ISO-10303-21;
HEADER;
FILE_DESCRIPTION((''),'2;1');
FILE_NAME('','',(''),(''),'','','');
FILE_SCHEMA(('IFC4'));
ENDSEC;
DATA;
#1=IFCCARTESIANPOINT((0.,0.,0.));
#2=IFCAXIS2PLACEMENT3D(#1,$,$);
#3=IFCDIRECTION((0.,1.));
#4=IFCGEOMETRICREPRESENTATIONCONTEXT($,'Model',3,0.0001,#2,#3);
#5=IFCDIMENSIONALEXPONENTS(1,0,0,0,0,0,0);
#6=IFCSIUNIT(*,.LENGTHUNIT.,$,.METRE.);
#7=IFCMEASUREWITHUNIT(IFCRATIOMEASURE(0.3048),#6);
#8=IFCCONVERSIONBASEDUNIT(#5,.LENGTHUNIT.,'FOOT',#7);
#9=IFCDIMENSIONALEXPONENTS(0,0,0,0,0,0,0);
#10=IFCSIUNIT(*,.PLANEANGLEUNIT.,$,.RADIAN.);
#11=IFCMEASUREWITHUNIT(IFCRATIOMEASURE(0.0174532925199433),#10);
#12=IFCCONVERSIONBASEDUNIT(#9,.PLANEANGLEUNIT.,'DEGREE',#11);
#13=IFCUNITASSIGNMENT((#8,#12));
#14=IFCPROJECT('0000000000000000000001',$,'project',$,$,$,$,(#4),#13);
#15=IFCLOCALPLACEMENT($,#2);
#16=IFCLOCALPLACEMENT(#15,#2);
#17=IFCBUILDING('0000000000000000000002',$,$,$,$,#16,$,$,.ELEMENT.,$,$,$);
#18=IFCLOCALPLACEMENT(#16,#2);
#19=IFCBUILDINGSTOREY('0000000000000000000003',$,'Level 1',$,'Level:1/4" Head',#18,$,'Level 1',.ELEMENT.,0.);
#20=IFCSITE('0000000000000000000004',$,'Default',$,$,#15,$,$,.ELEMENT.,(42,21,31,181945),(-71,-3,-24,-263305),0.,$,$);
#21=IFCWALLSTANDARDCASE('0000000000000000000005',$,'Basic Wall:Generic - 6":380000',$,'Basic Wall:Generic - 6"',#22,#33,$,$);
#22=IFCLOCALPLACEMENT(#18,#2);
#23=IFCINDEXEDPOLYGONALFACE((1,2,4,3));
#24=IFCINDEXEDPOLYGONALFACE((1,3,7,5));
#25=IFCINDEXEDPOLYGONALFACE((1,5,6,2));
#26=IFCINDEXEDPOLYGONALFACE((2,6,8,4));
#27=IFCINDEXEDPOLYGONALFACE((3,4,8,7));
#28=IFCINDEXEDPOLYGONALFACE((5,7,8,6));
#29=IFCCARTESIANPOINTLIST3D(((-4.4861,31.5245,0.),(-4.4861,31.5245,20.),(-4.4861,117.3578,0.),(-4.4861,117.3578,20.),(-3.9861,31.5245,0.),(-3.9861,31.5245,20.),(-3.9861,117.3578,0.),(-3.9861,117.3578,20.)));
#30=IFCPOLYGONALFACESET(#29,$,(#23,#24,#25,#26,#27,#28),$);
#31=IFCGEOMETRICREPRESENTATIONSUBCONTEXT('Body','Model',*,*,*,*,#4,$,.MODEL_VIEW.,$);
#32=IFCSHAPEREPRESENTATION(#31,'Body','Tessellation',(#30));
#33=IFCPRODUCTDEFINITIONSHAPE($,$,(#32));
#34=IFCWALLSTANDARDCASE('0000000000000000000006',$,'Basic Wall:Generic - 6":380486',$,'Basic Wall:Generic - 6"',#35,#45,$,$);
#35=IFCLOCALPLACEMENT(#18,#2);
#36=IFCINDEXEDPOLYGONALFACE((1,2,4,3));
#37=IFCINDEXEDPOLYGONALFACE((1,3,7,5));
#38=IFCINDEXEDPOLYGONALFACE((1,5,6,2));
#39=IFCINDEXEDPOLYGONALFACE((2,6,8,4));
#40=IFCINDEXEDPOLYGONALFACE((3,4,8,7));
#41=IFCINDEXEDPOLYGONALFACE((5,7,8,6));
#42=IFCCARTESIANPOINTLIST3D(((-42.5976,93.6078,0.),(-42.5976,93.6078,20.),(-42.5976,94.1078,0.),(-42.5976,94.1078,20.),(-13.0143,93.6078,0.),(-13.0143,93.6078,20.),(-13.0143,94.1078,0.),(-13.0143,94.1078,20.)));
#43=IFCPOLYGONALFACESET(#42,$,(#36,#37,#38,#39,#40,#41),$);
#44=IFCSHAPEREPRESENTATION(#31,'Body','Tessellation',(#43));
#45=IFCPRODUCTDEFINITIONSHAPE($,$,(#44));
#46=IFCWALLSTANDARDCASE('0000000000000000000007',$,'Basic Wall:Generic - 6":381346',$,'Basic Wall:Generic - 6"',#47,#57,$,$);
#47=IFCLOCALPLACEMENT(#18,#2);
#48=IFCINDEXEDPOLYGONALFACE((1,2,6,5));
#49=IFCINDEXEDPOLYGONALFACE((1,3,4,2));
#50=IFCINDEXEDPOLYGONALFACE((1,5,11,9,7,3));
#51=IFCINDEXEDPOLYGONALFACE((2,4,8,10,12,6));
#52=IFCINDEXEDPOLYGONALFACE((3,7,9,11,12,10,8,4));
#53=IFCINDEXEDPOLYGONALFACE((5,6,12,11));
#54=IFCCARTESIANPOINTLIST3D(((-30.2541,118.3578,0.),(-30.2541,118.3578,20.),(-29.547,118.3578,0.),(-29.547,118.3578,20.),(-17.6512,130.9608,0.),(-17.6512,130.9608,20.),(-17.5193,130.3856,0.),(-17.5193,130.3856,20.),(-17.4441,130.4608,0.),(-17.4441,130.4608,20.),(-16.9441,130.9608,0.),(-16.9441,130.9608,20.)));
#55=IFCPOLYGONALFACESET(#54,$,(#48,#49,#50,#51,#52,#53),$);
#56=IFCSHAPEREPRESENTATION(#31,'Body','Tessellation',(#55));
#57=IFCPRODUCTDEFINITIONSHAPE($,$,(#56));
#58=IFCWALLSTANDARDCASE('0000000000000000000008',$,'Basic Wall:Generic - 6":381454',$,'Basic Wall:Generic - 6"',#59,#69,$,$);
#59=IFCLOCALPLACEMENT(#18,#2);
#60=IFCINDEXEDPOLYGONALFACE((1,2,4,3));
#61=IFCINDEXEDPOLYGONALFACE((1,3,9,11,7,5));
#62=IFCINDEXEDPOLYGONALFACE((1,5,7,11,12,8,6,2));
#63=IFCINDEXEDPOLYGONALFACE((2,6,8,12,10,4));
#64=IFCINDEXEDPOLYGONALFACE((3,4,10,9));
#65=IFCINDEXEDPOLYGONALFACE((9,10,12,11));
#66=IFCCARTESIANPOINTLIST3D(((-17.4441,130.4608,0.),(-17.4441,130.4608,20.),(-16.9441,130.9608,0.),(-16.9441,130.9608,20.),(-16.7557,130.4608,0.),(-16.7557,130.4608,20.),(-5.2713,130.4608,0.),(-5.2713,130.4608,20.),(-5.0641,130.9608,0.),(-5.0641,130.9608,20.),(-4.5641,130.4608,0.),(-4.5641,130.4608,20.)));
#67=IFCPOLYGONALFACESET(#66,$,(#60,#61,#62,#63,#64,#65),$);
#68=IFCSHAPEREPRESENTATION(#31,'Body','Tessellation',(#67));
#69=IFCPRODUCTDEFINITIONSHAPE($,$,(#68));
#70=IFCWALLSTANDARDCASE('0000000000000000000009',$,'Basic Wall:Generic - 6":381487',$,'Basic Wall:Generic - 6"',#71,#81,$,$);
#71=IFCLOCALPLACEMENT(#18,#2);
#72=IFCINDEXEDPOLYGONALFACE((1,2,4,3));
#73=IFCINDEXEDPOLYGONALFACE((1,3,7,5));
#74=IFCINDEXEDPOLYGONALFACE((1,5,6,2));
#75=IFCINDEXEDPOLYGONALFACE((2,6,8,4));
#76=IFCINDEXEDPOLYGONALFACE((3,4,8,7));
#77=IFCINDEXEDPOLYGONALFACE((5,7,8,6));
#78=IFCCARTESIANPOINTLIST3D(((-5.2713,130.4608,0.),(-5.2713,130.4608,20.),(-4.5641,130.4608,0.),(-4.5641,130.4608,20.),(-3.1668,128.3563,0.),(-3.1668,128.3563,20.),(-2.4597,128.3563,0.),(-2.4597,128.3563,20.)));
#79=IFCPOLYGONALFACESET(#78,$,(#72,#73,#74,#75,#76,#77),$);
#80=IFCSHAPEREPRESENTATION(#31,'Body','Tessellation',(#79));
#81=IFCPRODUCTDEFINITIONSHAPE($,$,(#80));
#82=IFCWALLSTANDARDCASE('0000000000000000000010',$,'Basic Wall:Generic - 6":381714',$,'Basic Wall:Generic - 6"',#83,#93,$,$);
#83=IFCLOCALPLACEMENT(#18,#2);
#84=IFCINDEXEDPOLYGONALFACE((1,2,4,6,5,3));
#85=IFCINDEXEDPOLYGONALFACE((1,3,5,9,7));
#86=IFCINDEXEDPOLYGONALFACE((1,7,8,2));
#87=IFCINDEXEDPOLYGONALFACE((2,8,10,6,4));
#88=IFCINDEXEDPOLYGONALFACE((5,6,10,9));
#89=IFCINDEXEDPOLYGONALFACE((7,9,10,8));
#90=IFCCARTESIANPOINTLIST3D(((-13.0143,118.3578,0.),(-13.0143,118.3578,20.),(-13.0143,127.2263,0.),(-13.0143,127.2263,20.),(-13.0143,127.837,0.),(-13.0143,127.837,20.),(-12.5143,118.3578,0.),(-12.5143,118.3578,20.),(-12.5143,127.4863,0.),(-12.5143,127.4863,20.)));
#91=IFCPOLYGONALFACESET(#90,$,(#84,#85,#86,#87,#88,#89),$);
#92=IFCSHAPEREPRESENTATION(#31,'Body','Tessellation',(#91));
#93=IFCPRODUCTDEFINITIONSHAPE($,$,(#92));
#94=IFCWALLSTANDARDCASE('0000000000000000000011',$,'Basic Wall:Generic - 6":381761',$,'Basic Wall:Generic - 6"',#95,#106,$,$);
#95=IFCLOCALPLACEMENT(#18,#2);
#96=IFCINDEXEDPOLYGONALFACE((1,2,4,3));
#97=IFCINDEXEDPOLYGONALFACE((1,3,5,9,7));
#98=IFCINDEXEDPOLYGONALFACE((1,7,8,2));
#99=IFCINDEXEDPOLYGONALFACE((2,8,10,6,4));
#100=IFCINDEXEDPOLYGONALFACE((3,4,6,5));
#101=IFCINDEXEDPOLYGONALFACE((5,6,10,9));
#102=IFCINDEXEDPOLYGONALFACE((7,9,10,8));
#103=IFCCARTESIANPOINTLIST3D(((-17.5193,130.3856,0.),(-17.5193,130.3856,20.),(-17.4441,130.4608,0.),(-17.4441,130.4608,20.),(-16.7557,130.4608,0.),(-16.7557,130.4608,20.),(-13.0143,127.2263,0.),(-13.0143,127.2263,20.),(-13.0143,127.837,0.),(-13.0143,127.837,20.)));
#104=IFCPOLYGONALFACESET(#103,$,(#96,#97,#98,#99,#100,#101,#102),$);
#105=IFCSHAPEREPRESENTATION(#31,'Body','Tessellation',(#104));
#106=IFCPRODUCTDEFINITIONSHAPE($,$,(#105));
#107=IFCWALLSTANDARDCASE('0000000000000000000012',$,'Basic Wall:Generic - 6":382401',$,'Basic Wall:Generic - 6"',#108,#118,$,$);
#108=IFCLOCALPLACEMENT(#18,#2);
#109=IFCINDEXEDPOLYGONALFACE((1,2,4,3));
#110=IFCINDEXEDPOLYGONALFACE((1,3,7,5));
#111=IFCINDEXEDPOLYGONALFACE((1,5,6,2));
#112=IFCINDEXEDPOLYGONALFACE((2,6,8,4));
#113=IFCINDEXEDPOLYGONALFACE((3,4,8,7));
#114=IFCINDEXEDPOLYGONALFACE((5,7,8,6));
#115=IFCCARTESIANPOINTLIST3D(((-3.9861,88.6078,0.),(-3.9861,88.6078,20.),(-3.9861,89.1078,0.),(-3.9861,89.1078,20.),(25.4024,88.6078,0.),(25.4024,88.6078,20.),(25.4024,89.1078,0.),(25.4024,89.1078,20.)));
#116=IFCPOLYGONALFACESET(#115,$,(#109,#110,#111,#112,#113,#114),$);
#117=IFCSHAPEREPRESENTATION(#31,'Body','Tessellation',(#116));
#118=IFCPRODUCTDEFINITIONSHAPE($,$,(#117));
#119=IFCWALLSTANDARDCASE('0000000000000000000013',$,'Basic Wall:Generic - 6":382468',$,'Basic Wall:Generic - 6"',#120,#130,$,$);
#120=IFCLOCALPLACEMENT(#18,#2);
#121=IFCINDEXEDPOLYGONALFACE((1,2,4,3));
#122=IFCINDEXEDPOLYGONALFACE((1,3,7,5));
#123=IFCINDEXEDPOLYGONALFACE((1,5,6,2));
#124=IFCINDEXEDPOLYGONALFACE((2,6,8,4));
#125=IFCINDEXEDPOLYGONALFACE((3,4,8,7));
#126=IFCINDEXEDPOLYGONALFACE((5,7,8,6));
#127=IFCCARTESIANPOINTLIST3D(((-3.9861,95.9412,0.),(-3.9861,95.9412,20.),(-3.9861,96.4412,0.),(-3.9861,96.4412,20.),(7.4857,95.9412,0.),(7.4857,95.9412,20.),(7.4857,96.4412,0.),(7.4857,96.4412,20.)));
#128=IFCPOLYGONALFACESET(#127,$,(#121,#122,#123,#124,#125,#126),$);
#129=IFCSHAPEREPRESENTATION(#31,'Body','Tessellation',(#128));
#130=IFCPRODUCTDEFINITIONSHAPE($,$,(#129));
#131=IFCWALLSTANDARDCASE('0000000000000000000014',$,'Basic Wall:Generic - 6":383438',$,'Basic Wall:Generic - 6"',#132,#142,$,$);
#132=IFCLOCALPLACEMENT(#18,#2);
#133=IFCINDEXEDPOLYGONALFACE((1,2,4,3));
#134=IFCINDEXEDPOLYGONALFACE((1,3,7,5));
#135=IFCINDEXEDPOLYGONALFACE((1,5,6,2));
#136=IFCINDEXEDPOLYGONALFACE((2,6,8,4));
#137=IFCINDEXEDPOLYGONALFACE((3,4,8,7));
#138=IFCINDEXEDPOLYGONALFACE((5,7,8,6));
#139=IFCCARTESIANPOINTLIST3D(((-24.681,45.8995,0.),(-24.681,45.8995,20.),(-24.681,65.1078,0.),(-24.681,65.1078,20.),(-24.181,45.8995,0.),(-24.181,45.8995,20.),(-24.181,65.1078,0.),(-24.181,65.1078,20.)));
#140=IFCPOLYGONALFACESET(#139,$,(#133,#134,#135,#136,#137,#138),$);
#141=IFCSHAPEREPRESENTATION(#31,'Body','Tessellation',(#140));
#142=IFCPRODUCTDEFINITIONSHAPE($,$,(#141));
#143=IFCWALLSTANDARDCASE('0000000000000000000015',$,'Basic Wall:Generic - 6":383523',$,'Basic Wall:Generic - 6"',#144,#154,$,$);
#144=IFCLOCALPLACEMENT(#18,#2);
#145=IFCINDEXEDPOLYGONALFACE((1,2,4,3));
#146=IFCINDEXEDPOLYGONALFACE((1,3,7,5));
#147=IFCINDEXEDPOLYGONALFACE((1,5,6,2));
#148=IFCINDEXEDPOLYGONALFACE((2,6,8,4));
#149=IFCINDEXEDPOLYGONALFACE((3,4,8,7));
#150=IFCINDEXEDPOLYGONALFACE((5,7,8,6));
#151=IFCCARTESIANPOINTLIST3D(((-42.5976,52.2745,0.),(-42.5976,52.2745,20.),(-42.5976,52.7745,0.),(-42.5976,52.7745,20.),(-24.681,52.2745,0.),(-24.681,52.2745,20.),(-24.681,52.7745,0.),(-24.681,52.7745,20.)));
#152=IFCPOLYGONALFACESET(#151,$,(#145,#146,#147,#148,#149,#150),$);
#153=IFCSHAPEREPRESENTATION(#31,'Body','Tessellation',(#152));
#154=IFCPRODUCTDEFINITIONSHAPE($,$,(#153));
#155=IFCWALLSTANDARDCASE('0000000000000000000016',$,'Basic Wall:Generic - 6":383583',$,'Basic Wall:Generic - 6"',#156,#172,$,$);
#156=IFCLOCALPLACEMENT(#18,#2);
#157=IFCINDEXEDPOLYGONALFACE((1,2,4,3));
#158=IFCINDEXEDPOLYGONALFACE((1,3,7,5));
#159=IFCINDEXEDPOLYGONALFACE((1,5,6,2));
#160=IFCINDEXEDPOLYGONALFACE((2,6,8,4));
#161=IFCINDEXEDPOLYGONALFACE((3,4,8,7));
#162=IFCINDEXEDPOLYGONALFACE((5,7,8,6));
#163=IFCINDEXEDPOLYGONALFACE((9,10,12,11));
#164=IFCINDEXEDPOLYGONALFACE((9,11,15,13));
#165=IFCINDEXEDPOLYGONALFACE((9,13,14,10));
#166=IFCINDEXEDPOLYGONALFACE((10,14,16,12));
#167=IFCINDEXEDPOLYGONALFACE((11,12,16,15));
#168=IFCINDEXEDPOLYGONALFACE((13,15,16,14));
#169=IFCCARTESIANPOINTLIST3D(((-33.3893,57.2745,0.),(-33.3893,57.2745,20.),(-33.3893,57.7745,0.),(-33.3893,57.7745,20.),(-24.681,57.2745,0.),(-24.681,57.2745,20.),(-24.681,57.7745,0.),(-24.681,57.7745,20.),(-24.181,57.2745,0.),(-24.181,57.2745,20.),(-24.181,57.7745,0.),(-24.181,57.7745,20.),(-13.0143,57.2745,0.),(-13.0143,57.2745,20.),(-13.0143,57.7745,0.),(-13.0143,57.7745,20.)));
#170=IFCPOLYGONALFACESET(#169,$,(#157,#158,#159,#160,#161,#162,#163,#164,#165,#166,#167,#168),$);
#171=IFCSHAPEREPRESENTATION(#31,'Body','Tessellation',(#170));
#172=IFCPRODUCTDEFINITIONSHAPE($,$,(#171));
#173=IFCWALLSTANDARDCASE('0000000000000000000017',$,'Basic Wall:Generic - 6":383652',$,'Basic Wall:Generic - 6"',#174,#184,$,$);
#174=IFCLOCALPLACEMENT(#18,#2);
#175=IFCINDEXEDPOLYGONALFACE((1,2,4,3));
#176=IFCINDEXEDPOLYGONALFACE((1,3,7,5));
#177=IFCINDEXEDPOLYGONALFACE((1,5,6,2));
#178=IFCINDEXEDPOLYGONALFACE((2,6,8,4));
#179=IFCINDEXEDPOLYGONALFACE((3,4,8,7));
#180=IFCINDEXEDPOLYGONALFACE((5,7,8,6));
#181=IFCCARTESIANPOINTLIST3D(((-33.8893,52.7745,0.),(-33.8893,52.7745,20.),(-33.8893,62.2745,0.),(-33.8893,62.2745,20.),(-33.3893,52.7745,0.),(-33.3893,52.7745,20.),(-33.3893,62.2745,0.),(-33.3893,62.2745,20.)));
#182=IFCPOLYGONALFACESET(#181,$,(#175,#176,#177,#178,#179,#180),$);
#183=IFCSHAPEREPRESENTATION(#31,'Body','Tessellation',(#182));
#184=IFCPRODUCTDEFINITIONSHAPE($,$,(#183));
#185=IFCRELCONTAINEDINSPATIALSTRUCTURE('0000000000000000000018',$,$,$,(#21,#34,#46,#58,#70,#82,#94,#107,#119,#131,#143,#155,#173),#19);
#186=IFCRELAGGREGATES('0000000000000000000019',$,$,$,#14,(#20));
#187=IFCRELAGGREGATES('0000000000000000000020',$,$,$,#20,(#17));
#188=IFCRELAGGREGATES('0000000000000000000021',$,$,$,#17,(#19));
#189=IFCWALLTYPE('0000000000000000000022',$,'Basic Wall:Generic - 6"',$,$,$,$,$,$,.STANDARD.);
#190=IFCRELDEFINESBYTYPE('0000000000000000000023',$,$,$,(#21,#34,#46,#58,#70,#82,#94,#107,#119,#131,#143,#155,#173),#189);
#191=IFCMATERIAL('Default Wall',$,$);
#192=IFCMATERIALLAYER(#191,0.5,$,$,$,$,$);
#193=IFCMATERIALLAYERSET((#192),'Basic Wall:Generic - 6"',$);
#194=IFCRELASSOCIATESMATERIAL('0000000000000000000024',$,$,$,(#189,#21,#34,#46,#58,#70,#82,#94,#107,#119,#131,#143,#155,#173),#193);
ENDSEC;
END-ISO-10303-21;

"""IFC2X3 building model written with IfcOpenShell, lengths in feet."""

from ifc_helpers import new_model, entity, si_unit, converted_unit, direction, frame, frame_2d, origin, origin_2d_with_axis, place, context, subcontext, project, spatial, polyline, rectangle, outline, extrude, material, layer, layer_set, layer_usage, type_object, element, save


model = new_model("IFC2X3")

# Units and contexts
model_context = context("Model", 3, precision=0.0001, world=origin(), true_north=direction((0.0, 1.0)))
body_context = subcontext(model_context, "Body", "Model", "MODEL_VIEW")
ifc_project = project(units=[converted_unit("LENGTHUNIT", "FOOT", entity("IfcRatioMeasure", 0.3048), si_unit("LENGTHUNIT", "METRE"), dimensions=[1, 0, 0, 0, 0, 0, 0]), converted_unit("PLANEANGLEUNIT", "DEGREE", entity("IfcRatioMeasure", 0.0174532925199433), si_unit("PLANEANGLEUNIT", "RADIAN"), dimensions=[0, 0, 0, 0, 0, 0, 0])], contexts=[model_context])

# Site, building, storey
site_placement = place(None, origin())
site = spatial("IfcSite", under=ifc_project, at=site_placement, Name="Default", CompositionType="ELEMENT", RefLatitude=(42, 21, 31, 181945), RefLongitude=(-71, -3, -24, -263305), RefElevation=0.0)
building_placement = place(site_placement, origin())
building = spatial("IfcBuilding", under=site, at=building_placement, CompositionType="ELEMENT")
storey_placement = place(building_placement, origin())
storey = spatial("IfcBuildingStorey", under=building, at=storey_placement, Name="Level 1", ObjectType="Level:1/4\" Head", LongName="Level 1", CompositionType="ELEMENT", Elevation=0.0)

# Walls
ifc_material = material(Name="Default Wall")
ifc_layer = layer(ifc_material, 0.5)
ifc_layer_set = layer_set([ifc_layer], Name="Basic Wall:Generic - 6\"")
ifc_layer_usage_1 = layer_usage(ifc_layer_set, "AXIS2", "NEGATIVE", 0.25)
wall_type = type_object("IfcWallType", Name="Basic Wall:Generic - 6\"", PredefinedType="STANDARD", material=ifc_layer_set)
wall_1_placement = place(storey_placement, frame((-4.2361, 117.3578, 0.0), z_axis=(0.0, 0.0, 1.0), x_axis=(0.0, -1.0, 0.0)))
element("IfcWallStandardCase", 1, at=wall_1_placement, inside=storey, type_object=wall_type, material=ifc_layer_usage_1, Name="Basic Wall:Generic - 6\":380000", ObjectType="Basic Wall:Generic - 6\"", context=body_context, shape_type="SweptSolid", body=[
    extrude(rectangle(XDim=85.8333, YDim=0.5, at=frame_2d((42.9167, 0.0), x_axis=(-1.0, 0.0))), origin(), (0.0, 0.0, 1.0), 20.0),
])
ifc_layer_usage_2 = layer_usage(ifc_layer_set, "AXIS2", "NEGATIVE", 0.25)
wall_2_placement = place(storey_placement, frame((-42.5976, 93.8578, 0.0)))
element("IfcWallStandardCase", 2, at=wall_2_placement, inside=storey, type_object=wall_type, material=ifc_layer_usage_2, Name="Basic Wall:Generic - 6\":380486", ObjectType="Basic Wall:Generic - 6\"", context=body_context, shape_type="SweptSolid", body=[
    extrude(rectangle(XDim=29.5833, YDim=0.5, at=frame_2d((14.7917, 0.0), x_axis=(-1.0, 0.0))), origin(), (0.0, 0.0, 1.0), 20.0),
])
ifc_layer_usage_3 = layer_usage(ifc_layer_set, "AXIS2", "NEGATIVE", 0.25)
wall_3_placement = place(storey_placement, frame((-30.0773, 118.1811, 0.0), z_axis=(0.0, 0.0, 1.0), x_axis=(0.707107, 0.707107, 0.0)))
element("IfcWallStandardCase", 3, at=wall_3_placement, inside=storey, type_object=wall_type, material=ifc_layer_usage_3, Name="Basic Wall:Generic - 6\":381346", ObjectType="Basic Wall:Generic - 6\"", context=body_context, shape_type="SweptSolid", body=[
    extrude(outline(polyline([(18.3233, -0.25), (17.8233, 0.25), (0.0, 0.25), (0.5, -0.25), (17.5098, -0.25), (17.6162, -0.25), (18.3233, -0.25)])), origin(), (0.0, 0.0, 1.0), 20.0),
])
ifc_layer_usage_4 = layer_usage(ifc_layer_set, "AXIS2", "NEGATIVE", 0.25)
wall_4_placement = place(storey_placement, frame((-17.4441, 130.7108, 0.0)))
element("IfcWallStandardCase", 4, at=wall_4_placement, inside=storey, type_object=wall_type, material=ifc_layer_usage_4, Name="Basic Wall:Generic - 6\":381454", ObjectType="Basic Wall:Generic - 6\"", context=body_context, shape_type="SweptSolid", body=[
    extrude(outline(polyline([(12.8799, -0.25), (12.3799, 0.25), (0.5, 0.25), (0.0, -0.25), (0.6883, -0.25), (12.1728, -0.25), (12.8799, -0.25)])), origin(), (0.0, 0.0, 1.0), 20.0),
])
ifc_layer_usage_5 = layer_usage(ifc_layer_set, "AXIS2", "NEGATIVE", 0.25)
wall_5_placement = place(storey_placement, frame((-5.0945, 130.6376, 0.0), z_axis=(0.0, 0.0, 1.0), x_axis=(0.707107, -0.707107, 0.0)))
element("IfcWallStandardCase", 5, at=wall_5_placement, inside=storey, type_object=wall_type, material=ifc_layer_usage_5, Name="Basic Wall:Generic - 6\":381487", ObjectType="Basic Wall:Generic - 6\"", context=body_context, shape_type="SweptSolid", body=[
    extrude(outline(polyline([(2.9762, -0.25), (3.4762, 0.25), (0.5, 0.25), (0.0, -0.25), (2.9762, -0.25)])), origin(), (0.0, 0.0, 1.0), 20.0),
])
ifc_layer_usage_6 = layer_usage(ifc_layer_set, "AXIS2", "NEGATIVE", 0.25)
wall_6_placement = place(storey_placement, frame((-12.7643, 118.3578, 0.0), z_axis=(0.0, 0.0, 1.0), x_axis=(0.0, 1.0, 0.0)))
element("IfcWallStandardCase", 6, at=wall_6_placement, inside=storey, type_object=wall_type, material=ifc_layer_usage_6, Name="Basic Wall:Generic - 6\":381714", ObjectType="Basic Wall:Generic - 6\"", context=body_context, shape_type="SweptSolid", body=[
    extrude(outline(polyline([(9.1285, -0.25), (9.4791, 0.25), (8.8684, 0.25), (0.0, 0.25), (0.0, -0.25), (9.1285, -0.25)])), origin(), (0.0, 0.0, 1.0), 20.0),
])
ifc_layer_usage_7 = layer_usage(ifc_layer_set, "AXIS2", "NEGATIVE", 0.25)
wall_7_placement = place(storey_placement, frame((-12.8708, 127.431, 0.0), z_axis=(0.0, 0.0, 1.0), x_axis=(-0.818735, 0.574172, 0.0)))
element("IfcWallStandardCase", 7, at=wall_7_placement, inside=storey, type_object=wall_type, material=ifc_layer_usage_7, Name="Basic Wall:Generic - 6\":381761", ObjectType="Basic Wall:Generic - 6\"", context=body_context, shape_type="SweptSolid", body=[
    extrude(outline(polyline([(4.9204, -0.25), (5.484, 0.1452), (5.5024, 0.25), (0.0, 0.25), (0.3506, -0.25), (4.9204, -0.25)])), origin(), (0.0, 0.0, 1.0), 20.0),
])
ifc_layer_usage_8 = layer_usage(ifc_layer_set, "AXIS2", "NEGATIVE", 0.25)
wall_8_placement = place(storey_placement, frame((-3.9861, 88.8578, 0.0)))
element("IfcWallStandardCase", 8, at=wall_8_placement, inside=storey, type_object=wall_type, material=ifc_layer_usage_8, Name="Basic Wall:Generic - 6\":382401", ObjectType="Basic Wall:Generic - 6\"", context=body_context, shape_type="SweptSolid", body=[
    extrude(rectangle(XDim=29.3884, YDim=0.5, at=frame_2d((14.6942, 0.0), x_axis=(-1.0, 0.0))), origin(), (0.0, 0.0, 1.0), 20.0),
])
ifc_layer_usage_9 = layer_usage(ifc_layer_set, "AXIS2", "NEGATIVE", 0.25)
wall_9_placement = place(storey_placement, frame((-3.9861, 96.1912, 0.0)))
element("IfcWallStandardCase", 9, at=wall_9_placement, inside=storey, type_object=wall_type, material=ifc_layer_usage_9, Name="Basic Wall:Generic - 6\":382468", ObjectType="Basic Wall:Generic - 6\"", context=body_context, shape_type="SweptSolid", body=[
    extrude(rectangle(XDim=11.4718, YDim=0.5, at=frame_2d((5.7359, 0.0), x_axis=(-1.0, 0.0))), origin(), (0.0, 0.0, 1.0), 20.0),
])
ifc_layer_usage_10 = layer_usage(ifc_layer_set, "AXIS2", "NEGATIVE", 0.25)
wall_10_placement = place(storey_placement, frame((-24.431, 65.1078, 0.0), z_axis=(0.0, 0.0, 1.0), x_axis=(0.0, -1.0, 0.0)))
element("IfcWallStandardCase", 10, at=wall_10_placement, inside=storey, type_object=wall_type, material=ifc_layer_usage_10, Name="Basic Wall:Generic - 6\":383438", ObjectType="Basic Wall:Generic - 6\"", context=body_context, shape_type="SweptSolid", body=[
    extrude(rectangle(XDim=19.2083, YDim=0.5, at=frame_2d((9.6042, 0.0), x_axis=(-1.0, 0.0))), origin(), (0.0, 0.0, 1.0), 20.0),
])
ifc_layer_usage_11 = layer_usage(ifc_layer_set, "AXIS2", "NEGATIVE", 0.25)
wall_11_placement = place(storey_placement, frame((-24.681, 52.5245, 0.0), z_axis=(0.0, 0.0, 1.0), x_axis=(-1.0, 0.0, 0.0)))
element("IfcWallStandardCase", 11, at=wall_11_placement, inside=storey, type_object=wall_type, material=ifc_layer_usage_11, Name="Basic Wall:Generic - 6\":383523", ObjectType="Basic Wall:Generic - 6\"", context=body_context, shape_type="SweptSolid", body=[
    extrude(rectangle(XDim=17.9167, YDim=0.5, at=frame_2d((8.9583, 0.0), x_axis=(-1.0, 0.0))), origin(), (0.0, 0.0, 1.0), 20.0),
])

# Wall, opening
ifc_layer_usage_12 = layer_usage(ifc_layer_set, "AXIS2", "NEGATIVE", 0.25)
wall_12_placement = place(storey_placement, frame((-13.0143, 57.5245, 0.0), z_axis=(0.0, 0.0, 1.0), x_axis=(-1.0, 0.0, 0.0)))
wall_12 = element("IfcWallStandardCase", 12, at=wall_12_placement, inside=storey, type_object=wall_type, material=ifc_layer_usage_12, Name="Basic Wall:Generic - 6\":383583", ObjectType="Basic Wall:Generic - 6\"", context=body_context, shape_type="SweptSolid", body=[
    extrude(rectangle(XDim=20.375, YDim=0.5, at=frame_2d((10.1875, 0.0), x_axis=(-1.0, 0.0))), origin(), (0.0, 0.0, 1.0), 20.0),
])
opening_placement = place(storey_placement, frame((-13.0143, 57.5245, 0.0), z_axis=(0.0, 0.0, 1.0), x_axis=(-1.0, 0.0, 0.0)))
element("IfcOpeningElement", 13, at=opening_placement, cuts=wall_12, ObjectType="Opening", context=body_context, shape_type="SweptSolid", body=[
    extrude(rectangle(XDim=20.0, YDim=0.5, at=origin_2d_with_axis()), frame((11.6667, 0.0, 10.0), z_axis=(-1.0, 0.0, 0.0), x_axis=(0.0, 0.0, 1.0)), (0.0, 0.0, 1.0), 0.5),
])

# Wall
ifc_layer_usage_13 = layer_usage(ifc_layer_set, "AXIS2", "NEGATIVE", 0.25)
wall_13_placement = place(storey_placement, frame((-33.6393, 62.2745, 0.0), z_axis=(0.0, 0.0, 1.0), x_axis=(0.0, -1.0, 0.0)))
element("IfcWallStandardCase", 14, at=wall_13_placement, inside=storey, type_object=wall_type, material=ifc_layer_usage_13, Name="Basic Wall:Generic - 6\":383652", ObjectType="Basic Wall:Generic - 6\"", context=body_context, shape_type="SweptSolid", body=[
    extrude(rectangle(XDim=9.5, YDim=0.5, at=frame_2d((4.75, 0.0), x_axis=(-1.0, 0.0))), origin(), (0.0, 0.0, 1.0), 20.0),
])

save(model, "model.ifc")
